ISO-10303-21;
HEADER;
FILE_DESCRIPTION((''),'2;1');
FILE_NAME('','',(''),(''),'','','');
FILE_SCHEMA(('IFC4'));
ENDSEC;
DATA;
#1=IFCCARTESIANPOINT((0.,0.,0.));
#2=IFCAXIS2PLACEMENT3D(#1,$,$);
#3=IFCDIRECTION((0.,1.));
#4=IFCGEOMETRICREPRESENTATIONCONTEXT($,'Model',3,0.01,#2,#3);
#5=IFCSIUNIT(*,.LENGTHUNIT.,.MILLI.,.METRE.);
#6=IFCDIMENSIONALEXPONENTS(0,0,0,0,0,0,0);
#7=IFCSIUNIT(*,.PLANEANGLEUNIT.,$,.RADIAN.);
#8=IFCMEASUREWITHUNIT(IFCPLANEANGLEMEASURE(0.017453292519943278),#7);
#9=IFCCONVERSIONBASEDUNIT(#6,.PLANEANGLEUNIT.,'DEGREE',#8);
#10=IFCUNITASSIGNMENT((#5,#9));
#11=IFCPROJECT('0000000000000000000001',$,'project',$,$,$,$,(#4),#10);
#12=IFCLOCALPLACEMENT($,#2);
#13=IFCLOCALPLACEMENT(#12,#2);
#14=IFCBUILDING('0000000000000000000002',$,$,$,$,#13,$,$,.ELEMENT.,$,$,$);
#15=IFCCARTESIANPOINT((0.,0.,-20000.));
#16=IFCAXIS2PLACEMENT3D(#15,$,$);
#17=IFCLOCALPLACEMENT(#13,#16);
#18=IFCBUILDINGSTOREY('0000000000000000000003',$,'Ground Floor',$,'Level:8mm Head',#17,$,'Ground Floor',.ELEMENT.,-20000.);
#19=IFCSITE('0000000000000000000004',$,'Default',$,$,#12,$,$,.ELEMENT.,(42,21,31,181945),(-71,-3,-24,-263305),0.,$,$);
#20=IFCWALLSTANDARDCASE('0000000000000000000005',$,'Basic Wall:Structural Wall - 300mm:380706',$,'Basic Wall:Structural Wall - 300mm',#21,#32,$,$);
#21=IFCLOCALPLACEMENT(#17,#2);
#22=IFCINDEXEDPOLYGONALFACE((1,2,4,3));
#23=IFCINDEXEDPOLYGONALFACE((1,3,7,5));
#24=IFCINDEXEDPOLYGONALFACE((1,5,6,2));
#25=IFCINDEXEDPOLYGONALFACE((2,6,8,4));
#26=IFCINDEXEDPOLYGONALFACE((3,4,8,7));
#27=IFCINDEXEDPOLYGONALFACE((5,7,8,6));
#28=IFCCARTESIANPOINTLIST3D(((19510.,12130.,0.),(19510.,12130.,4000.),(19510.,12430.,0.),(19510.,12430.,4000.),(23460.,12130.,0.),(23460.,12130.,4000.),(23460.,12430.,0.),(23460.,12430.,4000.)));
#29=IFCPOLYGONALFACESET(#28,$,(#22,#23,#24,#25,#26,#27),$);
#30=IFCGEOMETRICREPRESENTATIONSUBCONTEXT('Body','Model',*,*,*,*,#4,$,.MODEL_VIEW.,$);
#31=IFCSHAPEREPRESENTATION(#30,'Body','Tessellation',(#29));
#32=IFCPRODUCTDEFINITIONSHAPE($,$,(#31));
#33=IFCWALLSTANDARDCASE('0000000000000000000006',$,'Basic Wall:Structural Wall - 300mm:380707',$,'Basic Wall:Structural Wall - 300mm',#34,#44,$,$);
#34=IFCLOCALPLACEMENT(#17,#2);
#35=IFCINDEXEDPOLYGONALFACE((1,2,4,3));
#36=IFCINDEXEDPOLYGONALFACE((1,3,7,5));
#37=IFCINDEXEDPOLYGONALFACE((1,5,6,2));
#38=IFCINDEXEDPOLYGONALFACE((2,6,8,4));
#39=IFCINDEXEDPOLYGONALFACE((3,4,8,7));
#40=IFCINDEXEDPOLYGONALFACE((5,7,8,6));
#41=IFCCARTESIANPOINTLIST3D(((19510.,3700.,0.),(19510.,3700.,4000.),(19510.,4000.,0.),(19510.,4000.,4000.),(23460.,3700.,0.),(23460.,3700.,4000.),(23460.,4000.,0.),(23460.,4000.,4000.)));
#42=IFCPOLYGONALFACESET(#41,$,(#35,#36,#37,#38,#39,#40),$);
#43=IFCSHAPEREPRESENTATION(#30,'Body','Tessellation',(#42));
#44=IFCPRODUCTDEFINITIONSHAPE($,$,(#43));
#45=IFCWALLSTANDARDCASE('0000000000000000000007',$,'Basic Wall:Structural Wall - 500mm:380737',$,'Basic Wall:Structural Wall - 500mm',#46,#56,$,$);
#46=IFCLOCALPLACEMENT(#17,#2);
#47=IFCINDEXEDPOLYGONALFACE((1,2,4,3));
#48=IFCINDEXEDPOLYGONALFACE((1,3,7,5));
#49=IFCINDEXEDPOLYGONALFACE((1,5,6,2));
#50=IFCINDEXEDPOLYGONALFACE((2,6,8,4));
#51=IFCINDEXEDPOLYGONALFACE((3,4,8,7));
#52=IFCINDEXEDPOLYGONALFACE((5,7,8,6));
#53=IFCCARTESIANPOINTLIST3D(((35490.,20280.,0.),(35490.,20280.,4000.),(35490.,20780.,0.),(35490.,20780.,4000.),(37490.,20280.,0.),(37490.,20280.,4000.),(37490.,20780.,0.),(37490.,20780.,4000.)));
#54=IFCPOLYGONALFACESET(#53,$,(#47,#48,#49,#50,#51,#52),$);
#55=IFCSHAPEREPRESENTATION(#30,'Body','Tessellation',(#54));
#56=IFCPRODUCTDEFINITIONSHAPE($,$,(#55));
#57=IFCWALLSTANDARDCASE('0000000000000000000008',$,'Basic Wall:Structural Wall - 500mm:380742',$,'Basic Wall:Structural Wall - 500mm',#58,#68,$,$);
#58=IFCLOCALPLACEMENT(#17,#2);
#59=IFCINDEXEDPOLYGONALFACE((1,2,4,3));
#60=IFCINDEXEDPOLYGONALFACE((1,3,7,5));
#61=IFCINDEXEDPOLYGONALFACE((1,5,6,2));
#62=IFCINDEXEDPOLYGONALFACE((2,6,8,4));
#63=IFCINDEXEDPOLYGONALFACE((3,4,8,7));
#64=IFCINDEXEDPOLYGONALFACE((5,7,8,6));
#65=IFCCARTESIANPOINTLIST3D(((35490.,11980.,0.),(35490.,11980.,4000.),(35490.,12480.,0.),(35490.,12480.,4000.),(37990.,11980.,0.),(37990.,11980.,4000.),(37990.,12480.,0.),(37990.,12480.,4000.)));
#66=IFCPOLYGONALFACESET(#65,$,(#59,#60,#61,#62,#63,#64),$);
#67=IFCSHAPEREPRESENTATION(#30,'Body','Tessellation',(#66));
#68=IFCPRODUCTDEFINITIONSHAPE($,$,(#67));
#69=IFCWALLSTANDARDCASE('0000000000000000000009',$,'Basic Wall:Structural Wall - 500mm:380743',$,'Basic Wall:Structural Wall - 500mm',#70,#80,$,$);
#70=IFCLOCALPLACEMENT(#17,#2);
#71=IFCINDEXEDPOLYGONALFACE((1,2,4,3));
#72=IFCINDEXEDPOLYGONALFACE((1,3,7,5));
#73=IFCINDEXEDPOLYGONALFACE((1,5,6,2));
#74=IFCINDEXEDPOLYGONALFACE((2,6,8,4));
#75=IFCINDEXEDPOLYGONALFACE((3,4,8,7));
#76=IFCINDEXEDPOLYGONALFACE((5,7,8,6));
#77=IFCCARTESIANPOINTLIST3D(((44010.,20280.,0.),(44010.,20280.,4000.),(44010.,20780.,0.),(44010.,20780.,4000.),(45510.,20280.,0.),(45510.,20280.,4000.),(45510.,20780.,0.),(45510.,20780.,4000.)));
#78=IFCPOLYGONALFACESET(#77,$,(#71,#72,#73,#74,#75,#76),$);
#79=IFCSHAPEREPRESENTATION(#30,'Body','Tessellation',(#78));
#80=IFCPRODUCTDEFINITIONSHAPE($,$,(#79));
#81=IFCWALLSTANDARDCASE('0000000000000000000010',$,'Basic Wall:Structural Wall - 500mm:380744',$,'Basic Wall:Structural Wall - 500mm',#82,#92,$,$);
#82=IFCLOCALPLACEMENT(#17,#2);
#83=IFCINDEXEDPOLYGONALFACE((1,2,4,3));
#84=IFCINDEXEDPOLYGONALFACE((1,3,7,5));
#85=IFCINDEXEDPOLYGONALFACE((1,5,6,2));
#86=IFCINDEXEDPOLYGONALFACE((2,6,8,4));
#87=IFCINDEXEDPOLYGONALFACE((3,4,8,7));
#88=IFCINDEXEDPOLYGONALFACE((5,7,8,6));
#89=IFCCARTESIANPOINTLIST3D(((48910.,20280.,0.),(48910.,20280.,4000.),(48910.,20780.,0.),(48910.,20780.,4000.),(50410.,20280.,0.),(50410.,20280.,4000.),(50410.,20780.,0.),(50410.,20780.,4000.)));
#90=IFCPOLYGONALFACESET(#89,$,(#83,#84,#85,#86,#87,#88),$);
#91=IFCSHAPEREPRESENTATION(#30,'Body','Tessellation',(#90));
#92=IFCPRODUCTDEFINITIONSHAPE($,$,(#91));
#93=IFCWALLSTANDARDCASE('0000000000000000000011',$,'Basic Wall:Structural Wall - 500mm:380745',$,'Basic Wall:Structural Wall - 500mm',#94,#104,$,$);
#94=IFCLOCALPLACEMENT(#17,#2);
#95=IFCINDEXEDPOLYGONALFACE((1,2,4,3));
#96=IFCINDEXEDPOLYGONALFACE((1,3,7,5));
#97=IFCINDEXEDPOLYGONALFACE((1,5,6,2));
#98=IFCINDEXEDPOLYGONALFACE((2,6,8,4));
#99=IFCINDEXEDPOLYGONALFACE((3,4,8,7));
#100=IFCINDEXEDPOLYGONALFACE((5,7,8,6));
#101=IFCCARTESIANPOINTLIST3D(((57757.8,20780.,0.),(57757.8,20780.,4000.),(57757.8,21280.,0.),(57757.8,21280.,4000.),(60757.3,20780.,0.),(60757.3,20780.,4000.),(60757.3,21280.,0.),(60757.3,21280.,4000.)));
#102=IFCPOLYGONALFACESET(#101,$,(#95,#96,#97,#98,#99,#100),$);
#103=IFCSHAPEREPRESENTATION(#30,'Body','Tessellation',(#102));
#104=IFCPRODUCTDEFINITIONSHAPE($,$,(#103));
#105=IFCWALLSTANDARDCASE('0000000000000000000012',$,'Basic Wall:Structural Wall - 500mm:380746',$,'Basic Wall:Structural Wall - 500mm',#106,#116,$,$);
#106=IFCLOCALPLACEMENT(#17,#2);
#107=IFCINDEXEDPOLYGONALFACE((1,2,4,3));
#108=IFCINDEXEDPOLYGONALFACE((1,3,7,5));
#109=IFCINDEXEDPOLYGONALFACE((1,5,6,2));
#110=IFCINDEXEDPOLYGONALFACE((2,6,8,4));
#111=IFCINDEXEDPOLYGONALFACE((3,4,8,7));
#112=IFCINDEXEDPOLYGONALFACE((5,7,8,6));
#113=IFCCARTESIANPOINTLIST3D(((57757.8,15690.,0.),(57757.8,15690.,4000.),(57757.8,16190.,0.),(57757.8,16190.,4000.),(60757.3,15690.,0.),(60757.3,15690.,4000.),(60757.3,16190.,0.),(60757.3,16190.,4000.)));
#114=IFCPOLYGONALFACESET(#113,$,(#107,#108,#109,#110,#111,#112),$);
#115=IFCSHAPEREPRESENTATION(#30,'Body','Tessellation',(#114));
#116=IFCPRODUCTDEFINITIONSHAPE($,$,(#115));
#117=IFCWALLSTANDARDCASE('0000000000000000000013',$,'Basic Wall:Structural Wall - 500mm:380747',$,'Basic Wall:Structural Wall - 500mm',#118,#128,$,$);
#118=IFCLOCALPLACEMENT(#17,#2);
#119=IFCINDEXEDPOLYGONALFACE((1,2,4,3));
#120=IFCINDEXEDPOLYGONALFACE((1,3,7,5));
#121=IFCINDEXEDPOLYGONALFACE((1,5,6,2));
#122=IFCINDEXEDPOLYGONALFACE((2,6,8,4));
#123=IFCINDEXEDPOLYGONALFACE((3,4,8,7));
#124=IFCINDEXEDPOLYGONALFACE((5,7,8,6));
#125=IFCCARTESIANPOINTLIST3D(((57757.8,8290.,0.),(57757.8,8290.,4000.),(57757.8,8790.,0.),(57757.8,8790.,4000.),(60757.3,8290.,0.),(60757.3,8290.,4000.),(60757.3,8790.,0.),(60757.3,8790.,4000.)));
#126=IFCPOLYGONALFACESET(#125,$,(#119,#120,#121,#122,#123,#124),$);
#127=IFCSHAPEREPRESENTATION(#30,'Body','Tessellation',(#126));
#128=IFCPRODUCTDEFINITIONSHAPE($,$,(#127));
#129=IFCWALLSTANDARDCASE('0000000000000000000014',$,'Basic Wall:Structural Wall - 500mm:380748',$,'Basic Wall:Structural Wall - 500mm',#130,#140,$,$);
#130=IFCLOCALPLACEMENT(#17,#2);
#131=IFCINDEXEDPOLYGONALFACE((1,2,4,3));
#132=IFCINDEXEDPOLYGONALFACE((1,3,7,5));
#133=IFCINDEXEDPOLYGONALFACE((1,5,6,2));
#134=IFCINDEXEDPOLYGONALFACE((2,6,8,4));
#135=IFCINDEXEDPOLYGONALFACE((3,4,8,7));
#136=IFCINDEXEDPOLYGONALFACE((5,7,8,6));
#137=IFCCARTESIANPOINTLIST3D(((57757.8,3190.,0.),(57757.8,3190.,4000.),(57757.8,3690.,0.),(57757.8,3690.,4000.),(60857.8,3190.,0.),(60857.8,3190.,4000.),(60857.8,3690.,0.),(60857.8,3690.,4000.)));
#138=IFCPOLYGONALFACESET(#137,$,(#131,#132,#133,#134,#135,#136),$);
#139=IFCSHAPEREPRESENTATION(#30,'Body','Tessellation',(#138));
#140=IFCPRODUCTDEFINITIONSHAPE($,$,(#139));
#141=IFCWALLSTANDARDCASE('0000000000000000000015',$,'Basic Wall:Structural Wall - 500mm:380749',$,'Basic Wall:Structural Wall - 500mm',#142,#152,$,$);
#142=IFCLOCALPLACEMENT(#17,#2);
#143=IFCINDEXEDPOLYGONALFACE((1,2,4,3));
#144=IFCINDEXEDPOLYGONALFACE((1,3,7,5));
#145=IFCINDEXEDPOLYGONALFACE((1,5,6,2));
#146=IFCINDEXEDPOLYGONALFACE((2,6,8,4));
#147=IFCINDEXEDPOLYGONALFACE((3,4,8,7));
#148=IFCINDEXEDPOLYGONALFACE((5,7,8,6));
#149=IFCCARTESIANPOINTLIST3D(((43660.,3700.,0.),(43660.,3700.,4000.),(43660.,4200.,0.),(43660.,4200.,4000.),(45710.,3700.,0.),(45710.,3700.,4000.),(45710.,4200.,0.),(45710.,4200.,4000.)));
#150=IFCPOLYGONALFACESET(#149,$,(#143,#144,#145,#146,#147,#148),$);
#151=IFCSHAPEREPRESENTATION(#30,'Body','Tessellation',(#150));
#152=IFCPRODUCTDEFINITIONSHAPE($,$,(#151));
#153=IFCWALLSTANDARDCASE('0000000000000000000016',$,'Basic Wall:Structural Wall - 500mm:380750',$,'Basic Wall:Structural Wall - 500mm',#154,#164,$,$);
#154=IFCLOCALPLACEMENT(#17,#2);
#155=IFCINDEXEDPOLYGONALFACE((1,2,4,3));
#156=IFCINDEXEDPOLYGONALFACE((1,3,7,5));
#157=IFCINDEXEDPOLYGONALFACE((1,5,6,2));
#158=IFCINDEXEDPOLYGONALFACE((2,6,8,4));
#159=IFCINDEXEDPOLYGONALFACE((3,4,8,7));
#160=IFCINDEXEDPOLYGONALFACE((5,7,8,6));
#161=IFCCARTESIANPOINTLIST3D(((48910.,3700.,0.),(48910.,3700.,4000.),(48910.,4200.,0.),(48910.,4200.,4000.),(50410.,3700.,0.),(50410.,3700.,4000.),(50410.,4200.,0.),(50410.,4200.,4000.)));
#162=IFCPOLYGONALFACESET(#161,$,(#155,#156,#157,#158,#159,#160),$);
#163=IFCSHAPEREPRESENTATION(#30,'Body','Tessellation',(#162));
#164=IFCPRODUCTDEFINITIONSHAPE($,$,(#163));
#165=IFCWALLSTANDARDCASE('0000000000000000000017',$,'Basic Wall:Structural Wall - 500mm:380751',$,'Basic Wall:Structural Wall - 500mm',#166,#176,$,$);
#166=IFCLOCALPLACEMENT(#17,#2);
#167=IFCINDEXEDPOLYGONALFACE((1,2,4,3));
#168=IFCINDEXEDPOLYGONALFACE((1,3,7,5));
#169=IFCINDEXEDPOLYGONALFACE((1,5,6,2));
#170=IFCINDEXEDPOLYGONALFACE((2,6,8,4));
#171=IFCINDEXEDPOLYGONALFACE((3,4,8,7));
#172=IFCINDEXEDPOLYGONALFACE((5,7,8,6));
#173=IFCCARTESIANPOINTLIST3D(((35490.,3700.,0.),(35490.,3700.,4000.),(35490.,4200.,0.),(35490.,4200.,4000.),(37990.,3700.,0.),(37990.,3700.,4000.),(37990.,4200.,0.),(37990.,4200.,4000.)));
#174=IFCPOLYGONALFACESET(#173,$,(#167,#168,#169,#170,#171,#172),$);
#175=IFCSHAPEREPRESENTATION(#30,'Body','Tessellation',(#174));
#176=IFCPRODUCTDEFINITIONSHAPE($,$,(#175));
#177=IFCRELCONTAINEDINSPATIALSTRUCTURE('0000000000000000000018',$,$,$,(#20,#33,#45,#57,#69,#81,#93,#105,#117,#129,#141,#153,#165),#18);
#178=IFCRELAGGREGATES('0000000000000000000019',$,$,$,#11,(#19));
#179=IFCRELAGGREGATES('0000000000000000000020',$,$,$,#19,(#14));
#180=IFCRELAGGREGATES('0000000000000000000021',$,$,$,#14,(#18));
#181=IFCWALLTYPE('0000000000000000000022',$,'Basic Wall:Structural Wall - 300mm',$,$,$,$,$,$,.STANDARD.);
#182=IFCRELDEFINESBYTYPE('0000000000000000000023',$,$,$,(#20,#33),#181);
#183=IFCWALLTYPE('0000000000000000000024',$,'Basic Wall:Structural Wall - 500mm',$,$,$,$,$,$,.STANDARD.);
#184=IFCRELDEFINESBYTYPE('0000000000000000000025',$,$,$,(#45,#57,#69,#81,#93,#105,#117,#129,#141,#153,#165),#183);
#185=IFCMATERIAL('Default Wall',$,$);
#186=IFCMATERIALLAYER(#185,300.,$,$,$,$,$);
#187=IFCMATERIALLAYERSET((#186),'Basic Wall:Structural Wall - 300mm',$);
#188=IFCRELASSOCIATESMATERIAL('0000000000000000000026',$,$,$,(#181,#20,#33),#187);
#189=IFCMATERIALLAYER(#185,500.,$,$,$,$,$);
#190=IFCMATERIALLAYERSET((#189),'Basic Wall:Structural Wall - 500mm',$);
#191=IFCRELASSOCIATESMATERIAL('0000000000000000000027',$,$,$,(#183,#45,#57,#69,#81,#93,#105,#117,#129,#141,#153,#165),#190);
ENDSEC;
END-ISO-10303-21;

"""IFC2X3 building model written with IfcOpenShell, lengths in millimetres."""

from ifc_helpers import new_model, entity, si_unit, converted_unit, direction, frame, frame_2d, origin, place, context, subcontext, project, spatial, rectangle, extrude, material, layer, layer_set, layer_usage, type_object, element, save


model = new_model("IFC2X3")

# Units and contexts
model_context = context("Model", 3, precision=0.01, world=origin(), true_north=direction((0.0, 1.0)))
body_context = subcontext(model_context, "Body", "Model", "MODEL_VIEW")
ifc_project = project(units=[si_unit("LENGTHUNIT", "METRE", prefix="MILLI"), converted_unit("PLANEANGLEUNIT", "DEGREE", entity("IfcPlaneAngleMeasure", 0.017453292519943278), si_unit("PLANEANGLEUNIT", "RADIAN"), dimensions=[0, 0, 0, 0, 0, 0, 0])], contexts=[model_context])

# Site, building, storey
site_placement = place(None, origin())
site = spatial("IfcSite", under=ifc_project, at=site_placement, Name="Default", CompositionType="ELEMENT", RefLatitude=(42, 21, 31, 181945), RefLongitude=(-71, -3, -24, -263305), RefElevation=0.0)
building_placement = place(site_placement, origin())
building = spatial("IfcBuilding", under=site, at=building_placement, CompositionType="ELEMENT")
storey_placement = place(building_placement, frame((0.0, 0.0, -20000.0)))
storey = spatial("IfcBuildingStorey", under=building, at=storey_placement, Name="Ground Floor", ObjectType="Level:8mm Head", LongName="Ground Floor", CompositionType="ELEMENT", Elevation=-20000.0)

# Walls
ifc_material_1 = material(Name="Default Wall")
ifc_layer_1 = layer(ifc_material_1, 300.0)
ifc_layer_set_1 = layer_set([ifc_layer_1], Name="Basic Wall:Structural Wall - 300mm")
ifc_layer_usage_1 = layer_usage(ifc_layer_set_1, "AXIS2", "NEGATIVE", 150.0)
wall_type_1 = type_object("IfcWallType", Name="Basic Wall:Structural Wall - 300mm", PredefinedType="STANDARD", material=ifc_layer_set_1)
wall_1_placement = place(storey_placement, frame((19510.0, 12280.0, 0.0)))
element("IfcWallStandardCase", 1, at=wall_1_placement, inside=storey, type_object=wall_type_1, material=ifc_layer_usage_1, Name="Basic Wall:Structural Wall - 300mm:380706", ObjectType="Basic Wall:Structural Wall - 300mm", context=body_context, shape_type="SweptSolid", body=[
    extrude(rectangle(XDim=3950.0, YDim=300.0, at=frame_2d((1975.0, 0.0), x_axis=(-1.0, 0.0))), origin(), (0.0, 0.0, 1.0), 4000.0),
])
ifc_layer_usage_2 = layer_usage(ifc_layer_set_1, "AXIS2", "NEGATIVE", 150.0)
wall_2_placement = place(storey_placement, frame((19510.0, 3850.0, 0.0)))
element("IfcWallStandardCase", 2, at=wall_2_placement, inside=storey, type_object=wall_type_1, material=ifc_layer_usage_2, Name="Basic Wall:Structural Wall - 300mm:380707", ObjectType="Basic Wall:Structural Wall - 300mm", context=body_context, shape_type="SweptSolid", body=[
    extrude(rectangle(XDim=3950.0, YDim=300.0, at=frame_2d((1975.0, 0.0), x_axis=(-1.0, 0.0))), origin(), (0.0, 0.0, 1.0), 4000.0),
])
ifc_layer_2 = layer(ifc_material_1, 500.0)
ifc_layer_set_2 = layer_set([ifc_layer_2], Name="Basic Wall:Structural Wall - 500mm")
ifc_layer_usage_3 = layer_usage(ifc_layer_set_2, "AXIS2", "NEGATIVE", 250.0)
wall_type_2 = type_object("IfcWallType", Name="Basic Wall:Structural Wall - 500mm", PredefinedType="STANDARD", material=ifc_layer_set_2)
wall_3_placement = place(storey_placement, frame((35490.0, 20530.0, 0.0)))
element("IfcWallStandardCase", 3, at=wall_3_placement, inside=storey, type_object=wall_type_2, material=ifc_layer_usage_3, Name="Basic Wall:Structural Wall - 500mm:380737", ObjectType="Basic Wall:Structural Wall - 500mm", context=body_context, shape_type="SweptSolid", body=[
    extrude(rectangle(XDim=2000.0, YDim=500.0, at=frame_2d((1000.0, 0.0), x_axis=(-1.0, 0.0))), origin(), (0.0, 0.0, 1.0), 4000.0),
])
ifc_layer_usage_4 = layer_usage(ifc_layer_set_2, "AXIS2", "NEGATIVE", 250.0)
wall_4_placement = place(storey_placement, frame((35490.0, 12230.0, 0.0)))
element("IfcWallStandardCase", 4, at=wall_4_placement, inside=storey, type_object=wall_type_2, material=ifc_layer_usage_4, Name="Basic Wall:Structural Wall - 500mm:380742", ObjectType="Basic Wall:Structural Wall - 500mm", context=body_context, shape_type="SweptSolid", body=[
    extrude(rectangle(XDim=2500.0, YDim=500.0, at=frame_2d((1250.0, 0.0), x_axis=(-1.0, 0.0))), origin(), (0.0, 0.0, 1.0), 4000.0),
])
ifc_layer_usage_5 = layer_usage(ifc_layer_set_2, "AXIS2", "NEGATIVE", 250.0)
wall_5_placement = place(storey_placement, frame((44010.0, 20530.0, 0.0)))
element("IfcWallStandardCase", 5, at=wall_5_placement, inside=storey, type_object=wall_type_2, material=ifc_layer_usage_5, Name="Basic Wall:Structural Wall - 500mm:380743", ObjectType="Basic Wall:Structural Wall - 500mm", context=body_context, shape_type="SweptSolid", body=[
    extrude(rectangle(XDim=1500.0, YDim=500.0, at=frame_2d((750.0, 0.0), x_axis=(-1.0, 0.0))), origin(), (0.0, 0.0, 1.0), 4000.0),
])
ifc_layer_usage_6 = layer_usage(ifc_layer_set_2, "AXIS2", "NEGATIVE", 250.0)
wall_6_placement = place(storey_placement, frame((48910.0, 20530.0, 0.0)))
element("IfcWallStandardCase", 6, at=wall_6_placement, inside=storey, type_object=wall_type_2, material=ifc_layer_usage_6, Name="Basic Wall:Structural Wall - 500mm:380744", ObjectType="Basic Wall:Structural Wall - 500mm", context=body_context, shape_type="SweptSolid", body=[
    extrude(rectangle(XDim=1500.0, YDim=500.0, at=frame_2d((750.0, 0.0), x_axis=(-1.0, 0.0))), origin(), (0.0, 0.0, 1.0), 4000.0),
])
ifc_layer_usage_7 = layer_usage(ifc_layer_set_2, "AXIS2", "NEGATIVE", 250.0)
wall_7_placement = place(storey_placement, frame((57757.8, 21030.0, 0.0)))
element("IfcWallStandardCase", 7, at=wall_7_placement, inside=storey, type_object=wall_type_2, material=ifc_layer_usage_7, Name="Basic Wall:Structural Wall - 500mm:380745", ObjectType="Basic Wall:Structural Wall - 500mm", context=body_context, shape_type="SweptSolid", body=[
    extrude(rectangle(XDim=2999.5, YDim=500.0, at=frame_2d((1499.8, 0.0), x_axis=(-1.0, 0.0))), origin(), (0.0, 0.0, 1.0), 4000.0),
])
ifc_layer_usage_8 = layer_usage(ifc_layer_set_2, "AXIS2", "NEGATIVE", 250.0)
wall_8_placement = place(storey_placement, frame((57757.8, 15940.0, 0.0)))
element("IfcWallStandardCase", 8, at=wall_8_placement, inside=storey, type_object=wall_type_2, material=ifc_layer_usage_8, Name="Basic Wall:Structural Wall - 500mm:380746", ObjectType="Basic Wall:Structural Wall - 500mm", context=body_context, shape_type="SweptSolid", body=[
    extrude(rectangle(XDim=2999.5, YDim=500.0, at=frame_2d((1499.8, 0.0), x_axis=(-1.0, 0.0))), origin(), (0.0, 0.0, 1.0), 4000.0),
])
ifc_layer_usage_9 = layer_usage(ifc_layer_set_2, "AXIS2", "NEGATIVE", 250.0)
wall_9_placement = place(storey_placement, frame((57757.8, 8540.0, 0.0)))
element("IfcWallStandardCase", 9, at=wall_9_placement, inside=storey, type_object=wall_type_2, material=ifc_layer_usage_9, Name="Basic Wall:Structural Wall - 500mm:380747", ObjectType="Basic Wall:Structural Wall - 500mm", context=body_context, shape_type="SweptSolid", body=[
    extrude(rectangle(XDim=2999.5, YDim=500.0, at=frame_2d((1499.8, 0.0), x_axis=(-1.0, 0.0))), origin(), (0.0, 0.0, 1.0), 4000.0),
])
ifc_layer_usage_10 = layer_usage(ifc_layer_set_2, "AXIS2", "NEGATIVE", 250.0)
wall_10_placement = place(storey_placement, frame((57757.8, 3440.0, 0.0)))
element("IfcWallStandardCase", 10, at=wall_10_placement, inside=storey, type_object=wall_type_2, material=ifc_layer_usage_10, Name="Basic Wall:Structural Wall - 500mm:380748", ObjectType="Basic Wall:Structural Wall - 500mm", context=body_context, shape_type="SweptSolid", body=[
    extrude(rectangle(XDim=3100.0, YDim=500.0, at=frame_2d((1550.0, 0.0), x_axis=(-1.0, 0.0))), origin(), (0.0, 0.0, 1.0), 4000.0),
])
ifc_layer_usage_11 = layer_usage(ifc_layer_set_2, "AXIS2", "NEGATIVE", 250.0)
wall_11_placement = place(storey_placement, frame((43660.0, 3950.0, 0.0)))
element("IfcWallStandardCase", 11, at=wall_11_placement, inside=storey, type_object=wall_type_2, material=ifc_layer_usage_11, Name="Basic Wall:Structural Wall - 500mm:380749", ObjectType="Basic Wall:Structural Wall - 500mm", context=body_context, shape_type="SweptSolid", body=[
    extrude(rectangle(XDim=2050.0, YDim=500.0, at=frame_2d((1025.0, 0.0), x_axis=(-1.0, 0.0))), origin(), (0.0, 0.0, 1.0), 4000.0),
])
ifc_layer_usage_12 = layer_usage(ifc_layer_set_2, "AXIS2", "NEGATIVE", 250.0)
wall_12_placement = place(storey_placement, frame((48910.0, 3950.0, 0.0)))
element("IfcWallStandardCase", 12, at=wall_12_placement, inside=storey, type_object=wall_type_2, material=ifc_layer_usage_12, Name="Basic Wall:Structural Wall - 500mm:380750", ObjectType="Basic Wall:Structural Wall - 500mm", context=body_context, shape_type="SweptSolid", body=[
    extrude(rectangle(XDim=1500.0, YDim=500.0, at=frame_2d((750.0, 0.0), x_axis=(-1.0, 0.0))), origin(), (0.0, 0.0, 1.0), 4000.0),
])
ifc_layer_usage_13 = layer_usage(ifc_layer_set_2, "AXIS2", "NEGATIVE", 250.0)
wall_13_placement = place(storey_placement, frame((35490.0, 3950.0, 0.0)))
element("IfcWallStandardCase", 13, at=wall_13_placement, inside=storey, type_object=wall_type_2, material=ifc_layer_usage_13, Name="Basic Wall:Structural Wall - 500mm:380751", ObjectType="Basic Wall:Structural Wall - 500mm", context=body_context, shape_type="SweptSolid", body=[
    extrude(rectangle(XDim=2500.0, YDim=500.0, at=frame_2d((1250.0, 0.0), x_axis=(-1.0, 0.0))), origin(), (0.0, 0.0, 1.0), 4000.0),
])

save(model, "model.ifc")
